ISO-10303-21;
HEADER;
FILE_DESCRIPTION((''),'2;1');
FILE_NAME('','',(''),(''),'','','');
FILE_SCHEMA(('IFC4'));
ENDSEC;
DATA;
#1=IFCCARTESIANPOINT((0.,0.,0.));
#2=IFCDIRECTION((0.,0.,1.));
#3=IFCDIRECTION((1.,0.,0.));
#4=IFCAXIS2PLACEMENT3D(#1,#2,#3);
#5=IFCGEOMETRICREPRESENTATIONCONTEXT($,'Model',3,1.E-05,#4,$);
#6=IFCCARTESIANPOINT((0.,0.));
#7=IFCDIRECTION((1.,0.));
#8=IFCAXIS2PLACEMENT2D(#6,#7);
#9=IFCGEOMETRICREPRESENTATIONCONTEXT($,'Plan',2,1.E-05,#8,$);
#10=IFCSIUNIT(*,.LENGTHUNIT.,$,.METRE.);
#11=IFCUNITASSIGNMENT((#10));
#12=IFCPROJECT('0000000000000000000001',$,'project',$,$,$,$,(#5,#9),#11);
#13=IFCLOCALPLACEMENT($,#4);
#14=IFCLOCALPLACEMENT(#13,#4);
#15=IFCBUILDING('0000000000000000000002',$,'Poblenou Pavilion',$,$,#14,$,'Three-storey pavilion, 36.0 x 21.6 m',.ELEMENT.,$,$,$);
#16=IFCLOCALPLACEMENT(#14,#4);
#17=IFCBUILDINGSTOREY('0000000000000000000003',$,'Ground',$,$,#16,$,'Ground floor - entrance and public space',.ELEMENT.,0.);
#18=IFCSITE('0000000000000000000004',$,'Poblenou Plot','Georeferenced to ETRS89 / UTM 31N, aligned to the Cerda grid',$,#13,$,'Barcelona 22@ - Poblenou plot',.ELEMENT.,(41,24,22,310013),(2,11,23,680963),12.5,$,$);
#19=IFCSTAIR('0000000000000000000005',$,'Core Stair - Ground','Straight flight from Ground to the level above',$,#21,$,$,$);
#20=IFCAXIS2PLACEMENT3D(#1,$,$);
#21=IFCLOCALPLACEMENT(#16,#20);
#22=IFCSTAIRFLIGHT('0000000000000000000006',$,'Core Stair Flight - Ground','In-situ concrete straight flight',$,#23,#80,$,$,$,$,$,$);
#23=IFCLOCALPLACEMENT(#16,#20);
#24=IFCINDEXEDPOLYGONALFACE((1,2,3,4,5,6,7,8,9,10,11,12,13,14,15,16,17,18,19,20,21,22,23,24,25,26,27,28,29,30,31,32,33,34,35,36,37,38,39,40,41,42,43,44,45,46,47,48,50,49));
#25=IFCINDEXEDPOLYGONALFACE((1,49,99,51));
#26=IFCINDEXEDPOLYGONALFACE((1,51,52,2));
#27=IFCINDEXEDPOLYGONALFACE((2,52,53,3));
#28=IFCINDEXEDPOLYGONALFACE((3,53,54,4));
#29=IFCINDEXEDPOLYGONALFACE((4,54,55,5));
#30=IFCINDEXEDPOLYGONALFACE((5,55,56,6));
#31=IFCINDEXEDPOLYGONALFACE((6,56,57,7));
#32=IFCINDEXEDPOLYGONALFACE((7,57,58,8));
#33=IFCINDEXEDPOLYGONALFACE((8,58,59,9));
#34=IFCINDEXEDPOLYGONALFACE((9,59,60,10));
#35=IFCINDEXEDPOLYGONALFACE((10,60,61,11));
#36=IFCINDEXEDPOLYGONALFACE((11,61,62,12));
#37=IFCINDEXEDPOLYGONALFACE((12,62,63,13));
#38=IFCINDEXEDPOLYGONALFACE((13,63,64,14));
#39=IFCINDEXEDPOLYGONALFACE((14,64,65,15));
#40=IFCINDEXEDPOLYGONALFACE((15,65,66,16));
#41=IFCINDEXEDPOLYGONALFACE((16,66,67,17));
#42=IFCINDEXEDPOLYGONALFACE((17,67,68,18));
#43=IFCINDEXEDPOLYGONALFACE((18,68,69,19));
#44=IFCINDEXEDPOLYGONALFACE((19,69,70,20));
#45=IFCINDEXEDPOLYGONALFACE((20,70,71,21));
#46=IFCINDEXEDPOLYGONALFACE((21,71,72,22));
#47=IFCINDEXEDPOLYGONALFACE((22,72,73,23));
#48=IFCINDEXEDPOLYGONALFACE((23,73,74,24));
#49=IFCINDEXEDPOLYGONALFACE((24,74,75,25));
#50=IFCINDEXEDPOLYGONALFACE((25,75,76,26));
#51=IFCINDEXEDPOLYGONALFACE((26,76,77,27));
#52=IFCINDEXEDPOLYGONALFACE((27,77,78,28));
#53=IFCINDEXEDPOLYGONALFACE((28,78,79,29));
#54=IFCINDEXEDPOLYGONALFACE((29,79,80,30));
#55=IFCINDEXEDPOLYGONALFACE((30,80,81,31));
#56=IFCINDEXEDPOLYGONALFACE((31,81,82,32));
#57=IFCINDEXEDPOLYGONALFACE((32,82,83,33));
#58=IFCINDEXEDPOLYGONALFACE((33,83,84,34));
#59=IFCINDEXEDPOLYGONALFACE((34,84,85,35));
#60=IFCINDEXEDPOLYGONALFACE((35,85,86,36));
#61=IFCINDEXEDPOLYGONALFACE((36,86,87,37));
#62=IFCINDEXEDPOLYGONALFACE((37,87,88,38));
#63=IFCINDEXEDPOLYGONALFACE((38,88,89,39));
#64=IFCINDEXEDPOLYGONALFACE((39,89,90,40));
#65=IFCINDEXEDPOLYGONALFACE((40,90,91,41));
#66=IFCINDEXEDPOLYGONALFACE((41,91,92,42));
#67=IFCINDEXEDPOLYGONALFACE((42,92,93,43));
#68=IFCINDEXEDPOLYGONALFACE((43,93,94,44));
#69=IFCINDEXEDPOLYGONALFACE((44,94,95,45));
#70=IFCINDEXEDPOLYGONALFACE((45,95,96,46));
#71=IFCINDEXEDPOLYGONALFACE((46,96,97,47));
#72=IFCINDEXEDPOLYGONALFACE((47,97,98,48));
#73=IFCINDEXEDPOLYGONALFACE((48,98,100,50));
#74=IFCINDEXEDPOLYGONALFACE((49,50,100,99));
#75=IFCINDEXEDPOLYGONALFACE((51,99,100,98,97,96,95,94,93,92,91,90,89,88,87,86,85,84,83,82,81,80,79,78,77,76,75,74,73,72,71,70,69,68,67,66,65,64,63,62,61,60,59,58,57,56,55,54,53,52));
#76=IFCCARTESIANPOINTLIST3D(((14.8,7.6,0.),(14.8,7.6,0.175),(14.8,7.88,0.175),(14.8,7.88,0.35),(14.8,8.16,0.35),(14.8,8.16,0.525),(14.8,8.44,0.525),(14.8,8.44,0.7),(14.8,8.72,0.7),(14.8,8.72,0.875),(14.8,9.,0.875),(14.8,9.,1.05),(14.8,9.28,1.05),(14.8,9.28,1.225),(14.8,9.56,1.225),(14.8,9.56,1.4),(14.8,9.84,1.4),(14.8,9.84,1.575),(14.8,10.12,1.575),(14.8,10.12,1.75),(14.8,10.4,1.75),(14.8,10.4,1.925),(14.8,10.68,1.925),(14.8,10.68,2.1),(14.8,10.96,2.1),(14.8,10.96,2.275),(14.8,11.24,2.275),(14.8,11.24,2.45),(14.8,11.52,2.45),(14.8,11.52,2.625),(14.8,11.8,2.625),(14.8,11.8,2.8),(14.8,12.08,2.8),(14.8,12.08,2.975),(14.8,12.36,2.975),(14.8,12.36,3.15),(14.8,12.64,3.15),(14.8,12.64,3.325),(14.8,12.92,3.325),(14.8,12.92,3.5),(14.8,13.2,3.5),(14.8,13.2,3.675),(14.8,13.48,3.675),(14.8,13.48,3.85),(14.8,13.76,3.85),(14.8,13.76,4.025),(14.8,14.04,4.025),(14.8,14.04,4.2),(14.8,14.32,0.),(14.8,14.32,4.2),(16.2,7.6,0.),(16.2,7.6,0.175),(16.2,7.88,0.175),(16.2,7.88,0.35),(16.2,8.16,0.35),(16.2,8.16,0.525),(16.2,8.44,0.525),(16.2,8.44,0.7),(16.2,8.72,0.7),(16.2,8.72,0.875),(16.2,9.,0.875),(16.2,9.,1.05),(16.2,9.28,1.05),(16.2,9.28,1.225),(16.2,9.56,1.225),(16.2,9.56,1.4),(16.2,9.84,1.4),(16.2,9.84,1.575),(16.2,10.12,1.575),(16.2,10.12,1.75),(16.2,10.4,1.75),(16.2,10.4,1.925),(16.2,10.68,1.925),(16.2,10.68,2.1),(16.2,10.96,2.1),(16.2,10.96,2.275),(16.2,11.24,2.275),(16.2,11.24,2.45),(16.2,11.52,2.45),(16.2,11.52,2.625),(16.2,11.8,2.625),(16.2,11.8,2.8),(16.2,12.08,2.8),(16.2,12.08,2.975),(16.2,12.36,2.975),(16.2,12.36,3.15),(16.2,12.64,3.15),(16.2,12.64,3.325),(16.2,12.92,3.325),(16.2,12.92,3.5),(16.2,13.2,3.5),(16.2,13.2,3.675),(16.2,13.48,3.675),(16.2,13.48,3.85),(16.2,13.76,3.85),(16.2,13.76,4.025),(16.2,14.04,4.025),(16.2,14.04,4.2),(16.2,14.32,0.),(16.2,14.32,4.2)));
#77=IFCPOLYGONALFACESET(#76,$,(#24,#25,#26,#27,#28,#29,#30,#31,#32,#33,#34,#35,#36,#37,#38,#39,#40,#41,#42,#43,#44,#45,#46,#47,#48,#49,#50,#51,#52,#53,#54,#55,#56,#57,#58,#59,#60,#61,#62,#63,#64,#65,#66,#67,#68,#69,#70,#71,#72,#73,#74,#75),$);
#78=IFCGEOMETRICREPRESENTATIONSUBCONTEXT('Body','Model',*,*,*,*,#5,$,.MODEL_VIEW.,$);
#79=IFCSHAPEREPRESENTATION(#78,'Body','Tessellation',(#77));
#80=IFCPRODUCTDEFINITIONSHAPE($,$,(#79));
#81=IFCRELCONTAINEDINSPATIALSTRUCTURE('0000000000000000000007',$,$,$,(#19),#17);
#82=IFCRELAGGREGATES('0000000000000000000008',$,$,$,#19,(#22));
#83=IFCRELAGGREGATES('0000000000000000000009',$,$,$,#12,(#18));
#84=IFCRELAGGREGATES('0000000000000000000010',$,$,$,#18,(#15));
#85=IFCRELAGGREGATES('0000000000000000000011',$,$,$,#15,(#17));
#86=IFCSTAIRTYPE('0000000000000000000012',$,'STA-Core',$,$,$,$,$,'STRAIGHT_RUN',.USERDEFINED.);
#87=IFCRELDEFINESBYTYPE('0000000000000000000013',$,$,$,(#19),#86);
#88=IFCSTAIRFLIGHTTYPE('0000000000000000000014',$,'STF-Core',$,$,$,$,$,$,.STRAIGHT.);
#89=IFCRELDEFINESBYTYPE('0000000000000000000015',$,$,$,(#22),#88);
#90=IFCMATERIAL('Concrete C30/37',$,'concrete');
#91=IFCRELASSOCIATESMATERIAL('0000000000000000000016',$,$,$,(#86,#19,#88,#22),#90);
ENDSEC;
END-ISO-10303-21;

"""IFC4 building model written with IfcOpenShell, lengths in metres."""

from ifc_helpers import new_model, si_unit, frame, origin_with_axes, origin_2d_with_axis, place, context, subcontext, project, spatial, line, indexed_curve, outline, extrude, material, type_object, element, aggregate, save


model = new_model("IFC4")

# Units and contexts
model_context = context("Model", 3, precision=1e-05, world=origin_with_axes())
plan_context = context("Plan", 2, precision=1e-05, world=origin_2d_with_axis())
body_context = subcontext(model_context, "Body", "Model", "MODEL_VIEW")
ifc_project = project(units=[si_unit("LENGTHUNIT", "METRE")], contexts=[model_context, plan_context])

# Site, building, storey
site_placement = place(None, origin_with_axes())
site = spatial("IfcSite", under=ifc_project, at=site_placement, Name="Poblenou Plot", Description="Georeferenced to ETRS89 / UTM 31N, aligned to the Cerda grid", LongName="Barcelona 22@ - Poblenou plot", CompositionType="ELEMENT", RefLatitude=(41, 24, 22, 310013), RefLongitude=(2, 11, 23, 680963), RefElevation=12.5)
building_placement = place(site_placement, origin_with_axes())
building = spatial("IfcBuilding", under=site, at=building_placement, Name="Poblenou Pavilion", LongName="Three-storey pavilion, 36.0 x 21.6 m", CompositionType="ELEMENT")
storey_placement = place(building_placement, origin_with_axes())
storey = spatial("IfcBuildingStorey", under=building, at=storey_placement, Name="Ground", LongName="Ground floor - entrance and public space", CompositionType="ELEMENT", Elevation=0.0)

# Stair, stair flight
ifc_material_1 = material(Name="Concrete C30/37", Category="concrete")
stair_type = type_object("IfcStairType", Name="STA-Core", ElementType="STRAIGHT_RUN", PredefinedType="USERDEFINED", material=ifc_material_1)
stair_placement = place(storey_placement, frame((14.8, 7.6, 0.0), z_axis=(0.0, 0.0, 1.0), x_axis=(1.0, 0.0, 0.0)))
stair = element("IfcStair", 1, at=stair_placement, inside=storey, type_object=stair_type, material=ifc_material_1, Name="Core Stair - Ground", Description="Straight flight from Ground to the level above")
stair_flight_type = type_object("IfcStairFlightType", Name="STF-Core", PredefinedType="STRAIGHT", material=ifc_material_1)
stair_flight_placement = place(stair_placement, frame((0.0, 0.0, 0.0), z_axis=(1.0, 0.0, 0.0), x_axis=(0.0, 1.0, 0.0)))
stair_flight = element("IfcStairFlight", 2, at=stair_flight_placement, type_object=stair_flight_type, material=ifc_material_1, Name="Core Stair Flight - Ground", Description="In-situ concrete straight flight", context=body_context, shape_type="SweptSolid", body=[
    extrude(outline(indexed_curve([(0.0, 0.0), (6.72, 0.0), (6.72, 4.2), (6.44, 4.2), (6.44, 4.025), (6.16, 4.025), (6.16, 3.85), (5.88, 3.85), (5.88, 3.675), (5.6, 3.675), (5.6, 3.5), (5.32, 3.5), (5.32, 3.325), (5.04, 3.325), (5.04, 3.15), (4.76, 3.15), (4.76, 2.975), (4.48, 2.975), (4.48, 2.8), (4.2, 2.8), (4.2, 2.625), (3.92, 2.625), (3.92, 2.45), (3.64, 2.45), (3.64, 2.275), (3.36, 2.275), (3.36, 2.1), (3.08, 2.1), (3.08, 1.925), (2.8, 1.925), (2.8, 1.75), (2.52, 1.75), (2.52, 1.575), (2.24, 1.575), (2.24, 1.4), (1.96, 1.4), (1.96, 1.225), (1.68, 1.225), (1.68, 1.05), (1.4, 1.05), (1.4, 0.875), (1.12, 0.875), (1.12, 0.7), (0.84, 0.7), (0.84, 0.525), (0.56, 0.525), (0.56, 0.35), (0.28, 0.35), (0.28, 0.175), (0.0, 0.175)], segments=[line(1, 2, 3, 4, 5, 6, 7, 8, 9, 10, 11, 12, 13, 14, 15, 16, 17, 18, 19, 20, 21, 22, 23, 24, 25, 26, 27, 28, 29, 30, 31, 32, 33, 34, 35, 36, 37, 38, 39, 40, 41, 42, 43, 44, 45, 46, 47, 48, 49, 50, 1)])), origin_with_axes(), (0.0, 0.0, 1.0), 1.4),
])
aggregate(stair, [stair_flight])

save(model, "model.ifc")
